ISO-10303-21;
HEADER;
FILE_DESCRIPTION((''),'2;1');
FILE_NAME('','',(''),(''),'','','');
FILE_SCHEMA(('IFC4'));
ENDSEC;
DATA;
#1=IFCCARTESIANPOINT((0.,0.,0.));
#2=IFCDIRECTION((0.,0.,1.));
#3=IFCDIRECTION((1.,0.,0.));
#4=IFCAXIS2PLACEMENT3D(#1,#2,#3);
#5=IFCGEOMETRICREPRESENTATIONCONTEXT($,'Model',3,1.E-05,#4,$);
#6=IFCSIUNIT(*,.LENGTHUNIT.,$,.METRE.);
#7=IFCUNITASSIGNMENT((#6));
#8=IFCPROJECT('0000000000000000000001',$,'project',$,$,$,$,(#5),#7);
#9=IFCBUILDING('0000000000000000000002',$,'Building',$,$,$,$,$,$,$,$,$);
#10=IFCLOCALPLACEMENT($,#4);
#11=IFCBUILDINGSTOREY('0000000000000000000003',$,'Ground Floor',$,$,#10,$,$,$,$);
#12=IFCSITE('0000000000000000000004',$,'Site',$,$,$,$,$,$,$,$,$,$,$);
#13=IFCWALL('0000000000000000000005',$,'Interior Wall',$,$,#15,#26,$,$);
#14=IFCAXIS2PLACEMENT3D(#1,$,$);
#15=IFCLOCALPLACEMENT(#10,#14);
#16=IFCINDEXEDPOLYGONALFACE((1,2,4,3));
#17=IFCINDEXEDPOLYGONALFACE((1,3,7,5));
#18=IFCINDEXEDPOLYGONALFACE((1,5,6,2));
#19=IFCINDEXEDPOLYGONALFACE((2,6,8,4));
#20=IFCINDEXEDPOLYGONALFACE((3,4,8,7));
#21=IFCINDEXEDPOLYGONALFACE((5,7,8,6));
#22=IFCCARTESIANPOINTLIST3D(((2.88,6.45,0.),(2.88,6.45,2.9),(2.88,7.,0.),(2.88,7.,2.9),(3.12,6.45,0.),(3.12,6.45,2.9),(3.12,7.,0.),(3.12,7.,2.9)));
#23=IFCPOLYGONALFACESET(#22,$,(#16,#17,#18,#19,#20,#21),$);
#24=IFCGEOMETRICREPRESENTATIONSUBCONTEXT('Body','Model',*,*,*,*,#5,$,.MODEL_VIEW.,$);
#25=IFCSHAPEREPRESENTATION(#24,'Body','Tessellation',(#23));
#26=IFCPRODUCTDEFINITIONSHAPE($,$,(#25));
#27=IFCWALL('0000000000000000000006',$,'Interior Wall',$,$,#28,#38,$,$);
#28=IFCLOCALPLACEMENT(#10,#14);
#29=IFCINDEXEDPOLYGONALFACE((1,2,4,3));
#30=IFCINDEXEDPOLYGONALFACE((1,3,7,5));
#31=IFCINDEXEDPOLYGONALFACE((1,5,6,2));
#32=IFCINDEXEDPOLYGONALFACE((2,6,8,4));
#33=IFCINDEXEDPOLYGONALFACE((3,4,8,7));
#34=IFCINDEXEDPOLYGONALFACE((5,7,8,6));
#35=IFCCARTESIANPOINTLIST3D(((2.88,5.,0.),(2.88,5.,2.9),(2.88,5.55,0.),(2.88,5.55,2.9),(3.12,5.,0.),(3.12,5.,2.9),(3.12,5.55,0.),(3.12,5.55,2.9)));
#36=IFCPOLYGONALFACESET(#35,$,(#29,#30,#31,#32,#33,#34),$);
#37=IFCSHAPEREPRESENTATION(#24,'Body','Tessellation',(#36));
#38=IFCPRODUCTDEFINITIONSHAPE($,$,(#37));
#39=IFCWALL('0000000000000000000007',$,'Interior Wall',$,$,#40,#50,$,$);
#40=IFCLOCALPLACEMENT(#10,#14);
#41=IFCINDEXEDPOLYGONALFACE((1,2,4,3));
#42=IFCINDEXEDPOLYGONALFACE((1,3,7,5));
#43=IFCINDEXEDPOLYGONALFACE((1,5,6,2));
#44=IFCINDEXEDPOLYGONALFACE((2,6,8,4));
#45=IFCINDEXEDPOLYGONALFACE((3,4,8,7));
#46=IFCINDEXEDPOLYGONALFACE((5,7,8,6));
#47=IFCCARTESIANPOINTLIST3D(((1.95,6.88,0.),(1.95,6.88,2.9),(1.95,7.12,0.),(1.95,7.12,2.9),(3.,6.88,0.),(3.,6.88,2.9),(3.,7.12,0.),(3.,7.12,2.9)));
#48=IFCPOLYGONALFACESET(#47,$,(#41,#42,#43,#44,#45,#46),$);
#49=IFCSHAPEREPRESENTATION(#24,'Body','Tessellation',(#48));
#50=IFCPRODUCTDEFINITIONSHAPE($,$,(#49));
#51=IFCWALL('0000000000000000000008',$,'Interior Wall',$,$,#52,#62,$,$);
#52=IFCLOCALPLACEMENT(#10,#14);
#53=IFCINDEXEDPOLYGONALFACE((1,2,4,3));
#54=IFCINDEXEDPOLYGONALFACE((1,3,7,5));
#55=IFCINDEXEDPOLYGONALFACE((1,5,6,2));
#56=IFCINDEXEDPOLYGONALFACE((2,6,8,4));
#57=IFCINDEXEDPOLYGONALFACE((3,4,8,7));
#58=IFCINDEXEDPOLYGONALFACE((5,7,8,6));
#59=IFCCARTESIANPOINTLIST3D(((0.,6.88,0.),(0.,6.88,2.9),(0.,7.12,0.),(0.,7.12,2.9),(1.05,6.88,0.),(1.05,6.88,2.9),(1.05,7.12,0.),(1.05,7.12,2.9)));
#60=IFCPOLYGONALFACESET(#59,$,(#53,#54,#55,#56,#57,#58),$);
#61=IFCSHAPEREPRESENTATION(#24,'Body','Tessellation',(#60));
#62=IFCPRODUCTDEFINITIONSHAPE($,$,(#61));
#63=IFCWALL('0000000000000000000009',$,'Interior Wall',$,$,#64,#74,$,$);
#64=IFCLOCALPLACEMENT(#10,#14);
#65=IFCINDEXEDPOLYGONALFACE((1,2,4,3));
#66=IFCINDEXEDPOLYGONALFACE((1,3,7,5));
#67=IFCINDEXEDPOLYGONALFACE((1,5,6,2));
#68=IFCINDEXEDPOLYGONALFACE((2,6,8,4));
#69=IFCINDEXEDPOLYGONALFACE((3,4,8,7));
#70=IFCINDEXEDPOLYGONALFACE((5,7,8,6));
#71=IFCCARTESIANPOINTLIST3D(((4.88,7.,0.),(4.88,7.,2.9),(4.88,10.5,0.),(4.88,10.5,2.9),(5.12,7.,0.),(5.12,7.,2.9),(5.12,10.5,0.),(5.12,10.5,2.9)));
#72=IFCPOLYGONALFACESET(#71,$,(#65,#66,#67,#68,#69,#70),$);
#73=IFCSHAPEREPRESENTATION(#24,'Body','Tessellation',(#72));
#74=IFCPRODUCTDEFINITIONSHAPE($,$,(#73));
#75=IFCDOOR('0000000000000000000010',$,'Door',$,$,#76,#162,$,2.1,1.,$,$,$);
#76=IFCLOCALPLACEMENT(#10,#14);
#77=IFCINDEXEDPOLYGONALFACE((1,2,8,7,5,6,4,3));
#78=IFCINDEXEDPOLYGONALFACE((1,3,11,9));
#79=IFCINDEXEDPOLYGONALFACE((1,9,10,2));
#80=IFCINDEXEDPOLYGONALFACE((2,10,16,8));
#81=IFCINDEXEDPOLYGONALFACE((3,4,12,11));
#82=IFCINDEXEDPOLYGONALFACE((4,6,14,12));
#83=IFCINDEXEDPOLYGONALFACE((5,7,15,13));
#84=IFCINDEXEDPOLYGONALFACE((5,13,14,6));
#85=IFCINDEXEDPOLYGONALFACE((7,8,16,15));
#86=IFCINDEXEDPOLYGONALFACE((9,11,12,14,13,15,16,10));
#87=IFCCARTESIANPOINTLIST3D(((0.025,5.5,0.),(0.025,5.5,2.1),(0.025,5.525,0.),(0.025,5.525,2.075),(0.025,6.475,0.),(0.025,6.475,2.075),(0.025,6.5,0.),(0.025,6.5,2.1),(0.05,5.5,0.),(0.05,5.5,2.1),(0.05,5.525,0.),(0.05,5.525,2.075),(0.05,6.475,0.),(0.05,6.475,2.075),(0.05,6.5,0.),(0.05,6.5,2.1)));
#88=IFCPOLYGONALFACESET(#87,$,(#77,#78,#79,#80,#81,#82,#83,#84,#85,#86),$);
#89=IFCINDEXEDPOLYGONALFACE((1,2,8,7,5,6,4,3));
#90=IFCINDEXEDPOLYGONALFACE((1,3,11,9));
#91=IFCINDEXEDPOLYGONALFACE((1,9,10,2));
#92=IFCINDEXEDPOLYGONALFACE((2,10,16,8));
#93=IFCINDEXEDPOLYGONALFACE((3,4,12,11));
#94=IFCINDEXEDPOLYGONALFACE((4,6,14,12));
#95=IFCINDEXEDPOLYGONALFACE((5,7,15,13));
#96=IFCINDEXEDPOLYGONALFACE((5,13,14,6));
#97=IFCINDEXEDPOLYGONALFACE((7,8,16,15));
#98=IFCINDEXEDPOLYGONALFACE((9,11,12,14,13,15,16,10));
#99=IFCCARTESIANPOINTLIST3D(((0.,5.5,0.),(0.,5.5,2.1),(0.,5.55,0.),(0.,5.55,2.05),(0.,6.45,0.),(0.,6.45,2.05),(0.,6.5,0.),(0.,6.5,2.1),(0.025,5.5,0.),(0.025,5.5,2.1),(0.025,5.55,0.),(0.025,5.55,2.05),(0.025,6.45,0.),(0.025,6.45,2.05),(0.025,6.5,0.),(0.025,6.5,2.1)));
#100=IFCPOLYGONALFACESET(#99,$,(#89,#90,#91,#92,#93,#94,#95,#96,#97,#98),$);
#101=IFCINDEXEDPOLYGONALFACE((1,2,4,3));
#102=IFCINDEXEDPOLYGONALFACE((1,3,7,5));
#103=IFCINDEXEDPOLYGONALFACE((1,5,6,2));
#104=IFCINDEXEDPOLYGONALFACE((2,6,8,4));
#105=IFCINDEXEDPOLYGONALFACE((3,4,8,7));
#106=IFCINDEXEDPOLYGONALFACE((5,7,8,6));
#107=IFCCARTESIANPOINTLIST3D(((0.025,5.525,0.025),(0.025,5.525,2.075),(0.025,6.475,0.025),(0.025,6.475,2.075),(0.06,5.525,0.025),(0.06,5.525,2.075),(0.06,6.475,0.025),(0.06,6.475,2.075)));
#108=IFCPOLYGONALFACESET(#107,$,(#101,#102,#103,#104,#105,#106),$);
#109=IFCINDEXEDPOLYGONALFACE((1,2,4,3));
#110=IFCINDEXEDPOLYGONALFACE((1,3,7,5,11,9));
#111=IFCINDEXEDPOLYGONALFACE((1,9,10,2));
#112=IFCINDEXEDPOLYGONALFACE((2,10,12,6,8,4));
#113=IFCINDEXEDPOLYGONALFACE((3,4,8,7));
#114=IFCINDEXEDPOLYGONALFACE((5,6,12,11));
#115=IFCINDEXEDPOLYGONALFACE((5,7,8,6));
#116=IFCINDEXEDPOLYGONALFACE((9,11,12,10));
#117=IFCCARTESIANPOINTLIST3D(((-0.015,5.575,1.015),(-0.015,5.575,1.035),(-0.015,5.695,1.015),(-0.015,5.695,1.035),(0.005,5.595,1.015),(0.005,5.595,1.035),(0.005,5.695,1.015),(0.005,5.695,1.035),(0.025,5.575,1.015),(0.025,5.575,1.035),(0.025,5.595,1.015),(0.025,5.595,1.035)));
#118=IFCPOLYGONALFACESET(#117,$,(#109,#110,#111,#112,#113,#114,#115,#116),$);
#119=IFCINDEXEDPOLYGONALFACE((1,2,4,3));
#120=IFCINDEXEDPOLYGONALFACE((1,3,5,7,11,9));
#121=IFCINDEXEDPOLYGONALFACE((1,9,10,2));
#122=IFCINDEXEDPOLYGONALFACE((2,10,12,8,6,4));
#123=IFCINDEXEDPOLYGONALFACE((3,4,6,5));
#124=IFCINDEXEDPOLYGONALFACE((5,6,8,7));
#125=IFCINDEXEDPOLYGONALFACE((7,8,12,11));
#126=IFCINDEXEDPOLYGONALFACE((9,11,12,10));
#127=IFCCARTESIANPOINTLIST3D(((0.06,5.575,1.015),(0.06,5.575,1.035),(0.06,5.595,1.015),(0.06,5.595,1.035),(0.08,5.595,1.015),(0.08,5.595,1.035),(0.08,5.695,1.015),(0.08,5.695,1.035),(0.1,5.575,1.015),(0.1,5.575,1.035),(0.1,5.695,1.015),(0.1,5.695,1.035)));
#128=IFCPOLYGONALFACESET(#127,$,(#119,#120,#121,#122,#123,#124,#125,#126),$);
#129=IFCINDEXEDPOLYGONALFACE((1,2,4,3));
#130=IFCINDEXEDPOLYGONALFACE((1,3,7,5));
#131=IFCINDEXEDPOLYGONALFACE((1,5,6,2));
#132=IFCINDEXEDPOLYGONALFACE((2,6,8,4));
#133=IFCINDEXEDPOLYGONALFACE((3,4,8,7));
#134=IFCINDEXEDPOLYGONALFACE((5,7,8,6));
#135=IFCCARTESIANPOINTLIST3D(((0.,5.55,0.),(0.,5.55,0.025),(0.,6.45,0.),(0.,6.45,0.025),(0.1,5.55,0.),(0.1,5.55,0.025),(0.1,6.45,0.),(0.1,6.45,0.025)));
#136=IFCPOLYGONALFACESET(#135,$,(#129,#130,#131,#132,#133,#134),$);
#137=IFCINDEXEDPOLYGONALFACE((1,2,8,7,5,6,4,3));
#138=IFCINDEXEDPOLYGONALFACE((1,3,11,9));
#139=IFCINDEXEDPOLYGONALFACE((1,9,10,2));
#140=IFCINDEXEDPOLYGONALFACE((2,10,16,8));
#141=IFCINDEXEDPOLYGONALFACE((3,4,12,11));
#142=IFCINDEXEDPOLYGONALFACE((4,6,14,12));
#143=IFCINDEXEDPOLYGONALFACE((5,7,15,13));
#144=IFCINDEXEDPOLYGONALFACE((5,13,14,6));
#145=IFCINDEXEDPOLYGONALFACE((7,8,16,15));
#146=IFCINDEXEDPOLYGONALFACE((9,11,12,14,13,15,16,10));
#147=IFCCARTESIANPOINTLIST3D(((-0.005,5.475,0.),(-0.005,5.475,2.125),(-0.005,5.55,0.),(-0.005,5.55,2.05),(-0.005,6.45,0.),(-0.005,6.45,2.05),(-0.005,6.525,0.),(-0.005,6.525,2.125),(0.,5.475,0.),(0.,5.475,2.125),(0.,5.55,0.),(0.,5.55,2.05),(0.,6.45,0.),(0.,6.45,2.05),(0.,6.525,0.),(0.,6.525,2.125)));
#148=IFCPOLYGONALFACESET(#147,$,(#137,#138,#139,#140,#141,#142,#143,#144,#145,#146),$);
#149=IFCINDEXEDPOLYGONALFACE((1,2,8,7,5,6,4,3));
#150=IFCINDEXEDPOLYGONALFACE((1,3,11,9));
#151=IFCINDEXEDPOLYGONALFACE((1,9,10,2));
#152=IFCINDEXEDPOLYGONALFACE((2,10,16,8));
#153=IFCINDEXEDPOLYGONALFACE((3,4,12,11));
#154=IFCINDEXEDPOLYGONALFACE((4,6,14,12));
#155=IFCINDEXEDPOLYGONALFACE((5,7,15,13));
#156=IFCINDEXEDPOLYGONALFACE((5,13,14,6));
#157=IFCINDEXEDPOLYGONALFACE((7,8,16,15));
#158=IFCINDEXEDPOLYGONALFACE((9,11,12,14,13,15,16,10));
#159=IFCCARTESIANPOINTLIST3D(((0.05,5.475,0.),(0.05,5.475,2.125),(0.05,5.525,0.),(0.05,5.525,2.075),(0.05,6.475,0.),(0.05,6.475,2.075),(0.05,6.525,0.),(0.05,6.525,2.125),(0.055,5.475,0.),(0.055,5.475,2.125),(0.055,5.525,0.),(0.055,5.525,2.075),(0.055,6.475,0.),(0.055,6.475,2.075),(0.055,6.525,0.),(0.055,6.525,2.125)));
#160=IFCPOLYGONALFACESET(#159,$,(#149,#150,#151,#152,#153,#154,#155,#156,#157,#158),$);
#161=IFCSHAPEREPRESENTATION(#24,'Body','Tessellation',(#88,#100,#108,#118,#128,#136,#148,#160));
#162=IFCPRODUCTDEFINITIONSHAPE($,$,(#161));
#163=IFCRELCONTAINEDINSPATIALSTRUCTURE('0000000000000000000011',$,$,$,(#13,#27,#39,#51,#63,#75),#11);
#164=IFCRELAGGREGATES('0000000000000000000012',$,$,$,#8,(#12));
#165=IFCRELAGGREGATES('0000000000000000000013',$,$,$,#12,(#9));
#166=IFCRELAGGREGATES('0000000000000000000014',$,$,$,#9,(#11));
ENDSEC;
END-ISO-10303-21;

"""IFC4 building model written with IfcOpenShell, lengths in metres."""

from ifc_helpers import new_model, si_unit, frame, origin_with_axes, place, context, subcontext, project, spatial, line, indexed_curve, outline, extrude, element, save


model = new_model("IFC4")

# Units and contexts
model_context = context("Model", 3, precision=1e-05, world=origin_with_axes())
body_context = subcontext(model_context, "Body", "Model", "MODEL_VIEW")
ifc_project = project(units=[si_unit("LENGTHUNIT", "METRE")], contexts=[model_context])

# Site, building, storey
site = spatial("IfcSite", under=ifc_project, Name="Site")
building = spatial("IfcBuilding", under=site, Name="Building")
storey_placement = place(None, origin_with_axes())
storey = spatial("IfcBuildingStorey", under=building, at=storey_placement, Name="Ground Floor")

# Walls
for number, where, z_axis, x_axis, name in (
    (1, (3.0, 7.0, 0.0), (0.0, 0.0, 1.0), (0.0, -1.0, 0.0), "Interior Wall"),
    (2, (3.0, 5.55, 0.0), (0.0, 0.0, 1.0), (0.0, -1.0, 0.0), "Interior Wall"),
):
    element("IfcWall", number, at=place(storey_placement, frame(where, z_axis=z_axis, x_axis=x_axis)), inside=storey, Name=name, context=body_context, shape_type="SweptSolid", body=[
        extrude(outline(indexed_curve([(0.0, 0.0), (0.0, 0.24), (0.55, 0.24), (0.55, 0.0), (0.0, 0.0)], self_intersect=False)), frame((0.0, -0.12, 0.0), z_axis=(0.0, 0.0, 1.0), x_axis=(1.0, 0.0, 0.0)), (0.0, 0.0, 1.0), 2.9),
    ])
for number, where, z_axis, x_axis, name in (
    (3, (3.0, 7.0, 0.0), (0.0, 0.0, 1.0), (-1.0, 0.0, 0.0), "Interior Wall"),
    (4, (1.05, 7.0, 0.0), (0.0, 0.0, 1.0), (-1.0, 0.0, 0.0), "Interior Wall"),
):
    element("IfcWall", number, at=place(storey_placement, frame(where, z_axis=z_axis, x_axis=x_axis)), inside=storey, Name=name, context=body_context, shape_type="SweptSolid", body=[
        extrude(outline(indexed_curve([(0.0, 0.0), (0.0, 0.24), (1.05, 0.24), (1.05, 0.0), (0.0, 0.0)], self_intersect=False)), frame((0.0, -0.12, 0.0), z_axis=(0.0, 0.0, 1.0), x_axis=(1.0, 0.0, 0.0)), (0.0, 0.0, 1.0), 2.9),
    ])
wall_1_placement = place(storey_placement, frame((5.0, 7.0, 0.0), z_axis=(0.0, 0.0, 1.0), x_axis=(0.0, 1.0, 0.0)))
element("IfcWall", 5, at=wall_1_placement, inside=storey, Name="Interior Wall", context=body_context, shape_type="SweptSolid", body=[
    extrude(outline(indexed_curve([(0.0, 0.0), (0.0, 0.24), (3.5, 0.24), (3.5, 0.0), (0.0, 0.0)], self_intersect=False)), frame((0.0, -0.12, 0.0), z_axis=(0.0, 0.0, 1.0), x_axis=(1.0, 0.0, 0.0)), (0.0, 0.0, 1.0), 2.9),
])

# Door
door_1_placement = place(storey_placement, frame((0.0, 6.5, 0.0), z_axis=(0.0, 0.0, 1.0), x_axis=(0.0, -1.0, 0.0)))
element("IfcDoor", 6, at=door_1_placement, inside=storey, Name="Door", OverallHeight=2.1, OverallWidth=1.0, context=body_context, shape_type="SweptSolid", body=[
    extrude(outline(indexed_curve([(0.0, 0.0), (0.0, 2.1), (1.0, 2.1), (1.0, 0.0), (0.975, 0.0), (0.975, 2.075), (0.025, 2.075), (0.025, 0.0)], segments=[line(1, 2, 3, 4, 5, 6, 7, 8, 1)])), frame((0.0, 0.025, 0.0), z_axis=(0.0, -1.0, 0.0), x_axis=(1.0, 0.0, 0.0)), (0.0, 0.0, -1.0), 0.025),
    extrude(outline(indexed_curve([(0.0, 0.0), (0.0, 2.1), (1.0, 2.1), (1.0, 0.0), (0.95, 0.0), (0.95, 2.05), (0.05, 2.05), (0.05, 0.0)], segments=[line(1, 2, 3, 4, 5, 6, 7, 8, 1)])), frame((0.0, 0.0, 0.0), z_axis=(0.0, -1.0, 0.0), x_axis=(1.0, 0.0, 0.0)), (0.0, 0.0, -1.0), 0.025),
    extrude(outline(indexed_curve([(0.0, 0.0), (0.95, 0.0), (0.95, 0.035), (0.0, 0.035)], segments=[line(1, 2, 3, 4, 1)])), frame((0.025, 0.025, 0.025), z_axis=(0.0, 0.0, 1.0), x_axis=(1.0, 0.0, 0.0)), (0.0, 0.0, 1.0), 2.05),
    extrude(outline(indexed_curve([(0.0, 0.0), (0.0, -0.04), (-0.12, -0.04), (-0.12, -0.02), (-0.02, -0.02), (-0.02, 0.0)], segments=[line(1, 2, 3, 4, 5, 6, 1)])), frame((0.925, 0.025, 1.015), z_axis=(0.0, 0.0, 1.0), x_axis=(1.0, 0.0, 0.0)), (0.0, 0.0, 1.0), 0.02),
    extrude(outline(indexed_curve([(0.0, 0.0), (0.0, 0.04), (-0.12, 0.04), (-0.12, 0.02), (-0.02, 0.02), (-0.02, 0.0)], segments=[line(1, 2, 3, 4, 5, 6, 1)])), frame((0.925, 0.06, 1.015), z_axis=(0.0, 0.0, 1.0), x_axis=(1.0, 0.0, 0.0)), (0.0, 0.0, 1.0), 0.02),
    extrude(outline(indexed_curve([(0.0, 0.0), (0.9, 0.0), (0.9, 0.1), (0.0, 0.1)], segments=[line(1, 2, 3, 4, 1)])), frame((0.05, 0.0, 0.0), z_axis=(0.0, 0.0, 1.0), x_axis=(1.0, 0.0, 0.0)), (0.0, 0.0, 1.0), 0.025),
    extrude(outline(indexed_curve([(0.0, 0.0), (0.0, 2.125), (1.05, 2.125), (1.05, 0.0), (0.975, 0.0), (0.975, 2.05), (0.075, 2.05), (0.075, 0.0)], segments=[line(1, 2, 3, 4, 5, 6, 7, 8, 1)])), frame((-0.025, -0.005, 0.0), z_axis=(0.0, -1.0, 0.0), x_axis=(1.0, 0.0, 0.0)), (0.0, 0.0, -1.0), 0.005),
    extrude(outline(indexed_curve([(0.0, 0.0), (0.0, 2.125), (1.05, 2.125), (1.05, 0.0), (1.0, 0.0), (1.0, 2.075), (0.05, 2.075), (0.05, 0.0)], segments=[line(1, 2, 3, 4, 5, 6, 7, 8, 1)])), frame((-0.025, 0.05, 0.0), z_axis=(0.0, -1.0, 0.0), x_axis=(1.0, 0.0, 0.0)), (0.0, 0.0, -1.0), 0.005),
])

save(model, "model.ifc")
